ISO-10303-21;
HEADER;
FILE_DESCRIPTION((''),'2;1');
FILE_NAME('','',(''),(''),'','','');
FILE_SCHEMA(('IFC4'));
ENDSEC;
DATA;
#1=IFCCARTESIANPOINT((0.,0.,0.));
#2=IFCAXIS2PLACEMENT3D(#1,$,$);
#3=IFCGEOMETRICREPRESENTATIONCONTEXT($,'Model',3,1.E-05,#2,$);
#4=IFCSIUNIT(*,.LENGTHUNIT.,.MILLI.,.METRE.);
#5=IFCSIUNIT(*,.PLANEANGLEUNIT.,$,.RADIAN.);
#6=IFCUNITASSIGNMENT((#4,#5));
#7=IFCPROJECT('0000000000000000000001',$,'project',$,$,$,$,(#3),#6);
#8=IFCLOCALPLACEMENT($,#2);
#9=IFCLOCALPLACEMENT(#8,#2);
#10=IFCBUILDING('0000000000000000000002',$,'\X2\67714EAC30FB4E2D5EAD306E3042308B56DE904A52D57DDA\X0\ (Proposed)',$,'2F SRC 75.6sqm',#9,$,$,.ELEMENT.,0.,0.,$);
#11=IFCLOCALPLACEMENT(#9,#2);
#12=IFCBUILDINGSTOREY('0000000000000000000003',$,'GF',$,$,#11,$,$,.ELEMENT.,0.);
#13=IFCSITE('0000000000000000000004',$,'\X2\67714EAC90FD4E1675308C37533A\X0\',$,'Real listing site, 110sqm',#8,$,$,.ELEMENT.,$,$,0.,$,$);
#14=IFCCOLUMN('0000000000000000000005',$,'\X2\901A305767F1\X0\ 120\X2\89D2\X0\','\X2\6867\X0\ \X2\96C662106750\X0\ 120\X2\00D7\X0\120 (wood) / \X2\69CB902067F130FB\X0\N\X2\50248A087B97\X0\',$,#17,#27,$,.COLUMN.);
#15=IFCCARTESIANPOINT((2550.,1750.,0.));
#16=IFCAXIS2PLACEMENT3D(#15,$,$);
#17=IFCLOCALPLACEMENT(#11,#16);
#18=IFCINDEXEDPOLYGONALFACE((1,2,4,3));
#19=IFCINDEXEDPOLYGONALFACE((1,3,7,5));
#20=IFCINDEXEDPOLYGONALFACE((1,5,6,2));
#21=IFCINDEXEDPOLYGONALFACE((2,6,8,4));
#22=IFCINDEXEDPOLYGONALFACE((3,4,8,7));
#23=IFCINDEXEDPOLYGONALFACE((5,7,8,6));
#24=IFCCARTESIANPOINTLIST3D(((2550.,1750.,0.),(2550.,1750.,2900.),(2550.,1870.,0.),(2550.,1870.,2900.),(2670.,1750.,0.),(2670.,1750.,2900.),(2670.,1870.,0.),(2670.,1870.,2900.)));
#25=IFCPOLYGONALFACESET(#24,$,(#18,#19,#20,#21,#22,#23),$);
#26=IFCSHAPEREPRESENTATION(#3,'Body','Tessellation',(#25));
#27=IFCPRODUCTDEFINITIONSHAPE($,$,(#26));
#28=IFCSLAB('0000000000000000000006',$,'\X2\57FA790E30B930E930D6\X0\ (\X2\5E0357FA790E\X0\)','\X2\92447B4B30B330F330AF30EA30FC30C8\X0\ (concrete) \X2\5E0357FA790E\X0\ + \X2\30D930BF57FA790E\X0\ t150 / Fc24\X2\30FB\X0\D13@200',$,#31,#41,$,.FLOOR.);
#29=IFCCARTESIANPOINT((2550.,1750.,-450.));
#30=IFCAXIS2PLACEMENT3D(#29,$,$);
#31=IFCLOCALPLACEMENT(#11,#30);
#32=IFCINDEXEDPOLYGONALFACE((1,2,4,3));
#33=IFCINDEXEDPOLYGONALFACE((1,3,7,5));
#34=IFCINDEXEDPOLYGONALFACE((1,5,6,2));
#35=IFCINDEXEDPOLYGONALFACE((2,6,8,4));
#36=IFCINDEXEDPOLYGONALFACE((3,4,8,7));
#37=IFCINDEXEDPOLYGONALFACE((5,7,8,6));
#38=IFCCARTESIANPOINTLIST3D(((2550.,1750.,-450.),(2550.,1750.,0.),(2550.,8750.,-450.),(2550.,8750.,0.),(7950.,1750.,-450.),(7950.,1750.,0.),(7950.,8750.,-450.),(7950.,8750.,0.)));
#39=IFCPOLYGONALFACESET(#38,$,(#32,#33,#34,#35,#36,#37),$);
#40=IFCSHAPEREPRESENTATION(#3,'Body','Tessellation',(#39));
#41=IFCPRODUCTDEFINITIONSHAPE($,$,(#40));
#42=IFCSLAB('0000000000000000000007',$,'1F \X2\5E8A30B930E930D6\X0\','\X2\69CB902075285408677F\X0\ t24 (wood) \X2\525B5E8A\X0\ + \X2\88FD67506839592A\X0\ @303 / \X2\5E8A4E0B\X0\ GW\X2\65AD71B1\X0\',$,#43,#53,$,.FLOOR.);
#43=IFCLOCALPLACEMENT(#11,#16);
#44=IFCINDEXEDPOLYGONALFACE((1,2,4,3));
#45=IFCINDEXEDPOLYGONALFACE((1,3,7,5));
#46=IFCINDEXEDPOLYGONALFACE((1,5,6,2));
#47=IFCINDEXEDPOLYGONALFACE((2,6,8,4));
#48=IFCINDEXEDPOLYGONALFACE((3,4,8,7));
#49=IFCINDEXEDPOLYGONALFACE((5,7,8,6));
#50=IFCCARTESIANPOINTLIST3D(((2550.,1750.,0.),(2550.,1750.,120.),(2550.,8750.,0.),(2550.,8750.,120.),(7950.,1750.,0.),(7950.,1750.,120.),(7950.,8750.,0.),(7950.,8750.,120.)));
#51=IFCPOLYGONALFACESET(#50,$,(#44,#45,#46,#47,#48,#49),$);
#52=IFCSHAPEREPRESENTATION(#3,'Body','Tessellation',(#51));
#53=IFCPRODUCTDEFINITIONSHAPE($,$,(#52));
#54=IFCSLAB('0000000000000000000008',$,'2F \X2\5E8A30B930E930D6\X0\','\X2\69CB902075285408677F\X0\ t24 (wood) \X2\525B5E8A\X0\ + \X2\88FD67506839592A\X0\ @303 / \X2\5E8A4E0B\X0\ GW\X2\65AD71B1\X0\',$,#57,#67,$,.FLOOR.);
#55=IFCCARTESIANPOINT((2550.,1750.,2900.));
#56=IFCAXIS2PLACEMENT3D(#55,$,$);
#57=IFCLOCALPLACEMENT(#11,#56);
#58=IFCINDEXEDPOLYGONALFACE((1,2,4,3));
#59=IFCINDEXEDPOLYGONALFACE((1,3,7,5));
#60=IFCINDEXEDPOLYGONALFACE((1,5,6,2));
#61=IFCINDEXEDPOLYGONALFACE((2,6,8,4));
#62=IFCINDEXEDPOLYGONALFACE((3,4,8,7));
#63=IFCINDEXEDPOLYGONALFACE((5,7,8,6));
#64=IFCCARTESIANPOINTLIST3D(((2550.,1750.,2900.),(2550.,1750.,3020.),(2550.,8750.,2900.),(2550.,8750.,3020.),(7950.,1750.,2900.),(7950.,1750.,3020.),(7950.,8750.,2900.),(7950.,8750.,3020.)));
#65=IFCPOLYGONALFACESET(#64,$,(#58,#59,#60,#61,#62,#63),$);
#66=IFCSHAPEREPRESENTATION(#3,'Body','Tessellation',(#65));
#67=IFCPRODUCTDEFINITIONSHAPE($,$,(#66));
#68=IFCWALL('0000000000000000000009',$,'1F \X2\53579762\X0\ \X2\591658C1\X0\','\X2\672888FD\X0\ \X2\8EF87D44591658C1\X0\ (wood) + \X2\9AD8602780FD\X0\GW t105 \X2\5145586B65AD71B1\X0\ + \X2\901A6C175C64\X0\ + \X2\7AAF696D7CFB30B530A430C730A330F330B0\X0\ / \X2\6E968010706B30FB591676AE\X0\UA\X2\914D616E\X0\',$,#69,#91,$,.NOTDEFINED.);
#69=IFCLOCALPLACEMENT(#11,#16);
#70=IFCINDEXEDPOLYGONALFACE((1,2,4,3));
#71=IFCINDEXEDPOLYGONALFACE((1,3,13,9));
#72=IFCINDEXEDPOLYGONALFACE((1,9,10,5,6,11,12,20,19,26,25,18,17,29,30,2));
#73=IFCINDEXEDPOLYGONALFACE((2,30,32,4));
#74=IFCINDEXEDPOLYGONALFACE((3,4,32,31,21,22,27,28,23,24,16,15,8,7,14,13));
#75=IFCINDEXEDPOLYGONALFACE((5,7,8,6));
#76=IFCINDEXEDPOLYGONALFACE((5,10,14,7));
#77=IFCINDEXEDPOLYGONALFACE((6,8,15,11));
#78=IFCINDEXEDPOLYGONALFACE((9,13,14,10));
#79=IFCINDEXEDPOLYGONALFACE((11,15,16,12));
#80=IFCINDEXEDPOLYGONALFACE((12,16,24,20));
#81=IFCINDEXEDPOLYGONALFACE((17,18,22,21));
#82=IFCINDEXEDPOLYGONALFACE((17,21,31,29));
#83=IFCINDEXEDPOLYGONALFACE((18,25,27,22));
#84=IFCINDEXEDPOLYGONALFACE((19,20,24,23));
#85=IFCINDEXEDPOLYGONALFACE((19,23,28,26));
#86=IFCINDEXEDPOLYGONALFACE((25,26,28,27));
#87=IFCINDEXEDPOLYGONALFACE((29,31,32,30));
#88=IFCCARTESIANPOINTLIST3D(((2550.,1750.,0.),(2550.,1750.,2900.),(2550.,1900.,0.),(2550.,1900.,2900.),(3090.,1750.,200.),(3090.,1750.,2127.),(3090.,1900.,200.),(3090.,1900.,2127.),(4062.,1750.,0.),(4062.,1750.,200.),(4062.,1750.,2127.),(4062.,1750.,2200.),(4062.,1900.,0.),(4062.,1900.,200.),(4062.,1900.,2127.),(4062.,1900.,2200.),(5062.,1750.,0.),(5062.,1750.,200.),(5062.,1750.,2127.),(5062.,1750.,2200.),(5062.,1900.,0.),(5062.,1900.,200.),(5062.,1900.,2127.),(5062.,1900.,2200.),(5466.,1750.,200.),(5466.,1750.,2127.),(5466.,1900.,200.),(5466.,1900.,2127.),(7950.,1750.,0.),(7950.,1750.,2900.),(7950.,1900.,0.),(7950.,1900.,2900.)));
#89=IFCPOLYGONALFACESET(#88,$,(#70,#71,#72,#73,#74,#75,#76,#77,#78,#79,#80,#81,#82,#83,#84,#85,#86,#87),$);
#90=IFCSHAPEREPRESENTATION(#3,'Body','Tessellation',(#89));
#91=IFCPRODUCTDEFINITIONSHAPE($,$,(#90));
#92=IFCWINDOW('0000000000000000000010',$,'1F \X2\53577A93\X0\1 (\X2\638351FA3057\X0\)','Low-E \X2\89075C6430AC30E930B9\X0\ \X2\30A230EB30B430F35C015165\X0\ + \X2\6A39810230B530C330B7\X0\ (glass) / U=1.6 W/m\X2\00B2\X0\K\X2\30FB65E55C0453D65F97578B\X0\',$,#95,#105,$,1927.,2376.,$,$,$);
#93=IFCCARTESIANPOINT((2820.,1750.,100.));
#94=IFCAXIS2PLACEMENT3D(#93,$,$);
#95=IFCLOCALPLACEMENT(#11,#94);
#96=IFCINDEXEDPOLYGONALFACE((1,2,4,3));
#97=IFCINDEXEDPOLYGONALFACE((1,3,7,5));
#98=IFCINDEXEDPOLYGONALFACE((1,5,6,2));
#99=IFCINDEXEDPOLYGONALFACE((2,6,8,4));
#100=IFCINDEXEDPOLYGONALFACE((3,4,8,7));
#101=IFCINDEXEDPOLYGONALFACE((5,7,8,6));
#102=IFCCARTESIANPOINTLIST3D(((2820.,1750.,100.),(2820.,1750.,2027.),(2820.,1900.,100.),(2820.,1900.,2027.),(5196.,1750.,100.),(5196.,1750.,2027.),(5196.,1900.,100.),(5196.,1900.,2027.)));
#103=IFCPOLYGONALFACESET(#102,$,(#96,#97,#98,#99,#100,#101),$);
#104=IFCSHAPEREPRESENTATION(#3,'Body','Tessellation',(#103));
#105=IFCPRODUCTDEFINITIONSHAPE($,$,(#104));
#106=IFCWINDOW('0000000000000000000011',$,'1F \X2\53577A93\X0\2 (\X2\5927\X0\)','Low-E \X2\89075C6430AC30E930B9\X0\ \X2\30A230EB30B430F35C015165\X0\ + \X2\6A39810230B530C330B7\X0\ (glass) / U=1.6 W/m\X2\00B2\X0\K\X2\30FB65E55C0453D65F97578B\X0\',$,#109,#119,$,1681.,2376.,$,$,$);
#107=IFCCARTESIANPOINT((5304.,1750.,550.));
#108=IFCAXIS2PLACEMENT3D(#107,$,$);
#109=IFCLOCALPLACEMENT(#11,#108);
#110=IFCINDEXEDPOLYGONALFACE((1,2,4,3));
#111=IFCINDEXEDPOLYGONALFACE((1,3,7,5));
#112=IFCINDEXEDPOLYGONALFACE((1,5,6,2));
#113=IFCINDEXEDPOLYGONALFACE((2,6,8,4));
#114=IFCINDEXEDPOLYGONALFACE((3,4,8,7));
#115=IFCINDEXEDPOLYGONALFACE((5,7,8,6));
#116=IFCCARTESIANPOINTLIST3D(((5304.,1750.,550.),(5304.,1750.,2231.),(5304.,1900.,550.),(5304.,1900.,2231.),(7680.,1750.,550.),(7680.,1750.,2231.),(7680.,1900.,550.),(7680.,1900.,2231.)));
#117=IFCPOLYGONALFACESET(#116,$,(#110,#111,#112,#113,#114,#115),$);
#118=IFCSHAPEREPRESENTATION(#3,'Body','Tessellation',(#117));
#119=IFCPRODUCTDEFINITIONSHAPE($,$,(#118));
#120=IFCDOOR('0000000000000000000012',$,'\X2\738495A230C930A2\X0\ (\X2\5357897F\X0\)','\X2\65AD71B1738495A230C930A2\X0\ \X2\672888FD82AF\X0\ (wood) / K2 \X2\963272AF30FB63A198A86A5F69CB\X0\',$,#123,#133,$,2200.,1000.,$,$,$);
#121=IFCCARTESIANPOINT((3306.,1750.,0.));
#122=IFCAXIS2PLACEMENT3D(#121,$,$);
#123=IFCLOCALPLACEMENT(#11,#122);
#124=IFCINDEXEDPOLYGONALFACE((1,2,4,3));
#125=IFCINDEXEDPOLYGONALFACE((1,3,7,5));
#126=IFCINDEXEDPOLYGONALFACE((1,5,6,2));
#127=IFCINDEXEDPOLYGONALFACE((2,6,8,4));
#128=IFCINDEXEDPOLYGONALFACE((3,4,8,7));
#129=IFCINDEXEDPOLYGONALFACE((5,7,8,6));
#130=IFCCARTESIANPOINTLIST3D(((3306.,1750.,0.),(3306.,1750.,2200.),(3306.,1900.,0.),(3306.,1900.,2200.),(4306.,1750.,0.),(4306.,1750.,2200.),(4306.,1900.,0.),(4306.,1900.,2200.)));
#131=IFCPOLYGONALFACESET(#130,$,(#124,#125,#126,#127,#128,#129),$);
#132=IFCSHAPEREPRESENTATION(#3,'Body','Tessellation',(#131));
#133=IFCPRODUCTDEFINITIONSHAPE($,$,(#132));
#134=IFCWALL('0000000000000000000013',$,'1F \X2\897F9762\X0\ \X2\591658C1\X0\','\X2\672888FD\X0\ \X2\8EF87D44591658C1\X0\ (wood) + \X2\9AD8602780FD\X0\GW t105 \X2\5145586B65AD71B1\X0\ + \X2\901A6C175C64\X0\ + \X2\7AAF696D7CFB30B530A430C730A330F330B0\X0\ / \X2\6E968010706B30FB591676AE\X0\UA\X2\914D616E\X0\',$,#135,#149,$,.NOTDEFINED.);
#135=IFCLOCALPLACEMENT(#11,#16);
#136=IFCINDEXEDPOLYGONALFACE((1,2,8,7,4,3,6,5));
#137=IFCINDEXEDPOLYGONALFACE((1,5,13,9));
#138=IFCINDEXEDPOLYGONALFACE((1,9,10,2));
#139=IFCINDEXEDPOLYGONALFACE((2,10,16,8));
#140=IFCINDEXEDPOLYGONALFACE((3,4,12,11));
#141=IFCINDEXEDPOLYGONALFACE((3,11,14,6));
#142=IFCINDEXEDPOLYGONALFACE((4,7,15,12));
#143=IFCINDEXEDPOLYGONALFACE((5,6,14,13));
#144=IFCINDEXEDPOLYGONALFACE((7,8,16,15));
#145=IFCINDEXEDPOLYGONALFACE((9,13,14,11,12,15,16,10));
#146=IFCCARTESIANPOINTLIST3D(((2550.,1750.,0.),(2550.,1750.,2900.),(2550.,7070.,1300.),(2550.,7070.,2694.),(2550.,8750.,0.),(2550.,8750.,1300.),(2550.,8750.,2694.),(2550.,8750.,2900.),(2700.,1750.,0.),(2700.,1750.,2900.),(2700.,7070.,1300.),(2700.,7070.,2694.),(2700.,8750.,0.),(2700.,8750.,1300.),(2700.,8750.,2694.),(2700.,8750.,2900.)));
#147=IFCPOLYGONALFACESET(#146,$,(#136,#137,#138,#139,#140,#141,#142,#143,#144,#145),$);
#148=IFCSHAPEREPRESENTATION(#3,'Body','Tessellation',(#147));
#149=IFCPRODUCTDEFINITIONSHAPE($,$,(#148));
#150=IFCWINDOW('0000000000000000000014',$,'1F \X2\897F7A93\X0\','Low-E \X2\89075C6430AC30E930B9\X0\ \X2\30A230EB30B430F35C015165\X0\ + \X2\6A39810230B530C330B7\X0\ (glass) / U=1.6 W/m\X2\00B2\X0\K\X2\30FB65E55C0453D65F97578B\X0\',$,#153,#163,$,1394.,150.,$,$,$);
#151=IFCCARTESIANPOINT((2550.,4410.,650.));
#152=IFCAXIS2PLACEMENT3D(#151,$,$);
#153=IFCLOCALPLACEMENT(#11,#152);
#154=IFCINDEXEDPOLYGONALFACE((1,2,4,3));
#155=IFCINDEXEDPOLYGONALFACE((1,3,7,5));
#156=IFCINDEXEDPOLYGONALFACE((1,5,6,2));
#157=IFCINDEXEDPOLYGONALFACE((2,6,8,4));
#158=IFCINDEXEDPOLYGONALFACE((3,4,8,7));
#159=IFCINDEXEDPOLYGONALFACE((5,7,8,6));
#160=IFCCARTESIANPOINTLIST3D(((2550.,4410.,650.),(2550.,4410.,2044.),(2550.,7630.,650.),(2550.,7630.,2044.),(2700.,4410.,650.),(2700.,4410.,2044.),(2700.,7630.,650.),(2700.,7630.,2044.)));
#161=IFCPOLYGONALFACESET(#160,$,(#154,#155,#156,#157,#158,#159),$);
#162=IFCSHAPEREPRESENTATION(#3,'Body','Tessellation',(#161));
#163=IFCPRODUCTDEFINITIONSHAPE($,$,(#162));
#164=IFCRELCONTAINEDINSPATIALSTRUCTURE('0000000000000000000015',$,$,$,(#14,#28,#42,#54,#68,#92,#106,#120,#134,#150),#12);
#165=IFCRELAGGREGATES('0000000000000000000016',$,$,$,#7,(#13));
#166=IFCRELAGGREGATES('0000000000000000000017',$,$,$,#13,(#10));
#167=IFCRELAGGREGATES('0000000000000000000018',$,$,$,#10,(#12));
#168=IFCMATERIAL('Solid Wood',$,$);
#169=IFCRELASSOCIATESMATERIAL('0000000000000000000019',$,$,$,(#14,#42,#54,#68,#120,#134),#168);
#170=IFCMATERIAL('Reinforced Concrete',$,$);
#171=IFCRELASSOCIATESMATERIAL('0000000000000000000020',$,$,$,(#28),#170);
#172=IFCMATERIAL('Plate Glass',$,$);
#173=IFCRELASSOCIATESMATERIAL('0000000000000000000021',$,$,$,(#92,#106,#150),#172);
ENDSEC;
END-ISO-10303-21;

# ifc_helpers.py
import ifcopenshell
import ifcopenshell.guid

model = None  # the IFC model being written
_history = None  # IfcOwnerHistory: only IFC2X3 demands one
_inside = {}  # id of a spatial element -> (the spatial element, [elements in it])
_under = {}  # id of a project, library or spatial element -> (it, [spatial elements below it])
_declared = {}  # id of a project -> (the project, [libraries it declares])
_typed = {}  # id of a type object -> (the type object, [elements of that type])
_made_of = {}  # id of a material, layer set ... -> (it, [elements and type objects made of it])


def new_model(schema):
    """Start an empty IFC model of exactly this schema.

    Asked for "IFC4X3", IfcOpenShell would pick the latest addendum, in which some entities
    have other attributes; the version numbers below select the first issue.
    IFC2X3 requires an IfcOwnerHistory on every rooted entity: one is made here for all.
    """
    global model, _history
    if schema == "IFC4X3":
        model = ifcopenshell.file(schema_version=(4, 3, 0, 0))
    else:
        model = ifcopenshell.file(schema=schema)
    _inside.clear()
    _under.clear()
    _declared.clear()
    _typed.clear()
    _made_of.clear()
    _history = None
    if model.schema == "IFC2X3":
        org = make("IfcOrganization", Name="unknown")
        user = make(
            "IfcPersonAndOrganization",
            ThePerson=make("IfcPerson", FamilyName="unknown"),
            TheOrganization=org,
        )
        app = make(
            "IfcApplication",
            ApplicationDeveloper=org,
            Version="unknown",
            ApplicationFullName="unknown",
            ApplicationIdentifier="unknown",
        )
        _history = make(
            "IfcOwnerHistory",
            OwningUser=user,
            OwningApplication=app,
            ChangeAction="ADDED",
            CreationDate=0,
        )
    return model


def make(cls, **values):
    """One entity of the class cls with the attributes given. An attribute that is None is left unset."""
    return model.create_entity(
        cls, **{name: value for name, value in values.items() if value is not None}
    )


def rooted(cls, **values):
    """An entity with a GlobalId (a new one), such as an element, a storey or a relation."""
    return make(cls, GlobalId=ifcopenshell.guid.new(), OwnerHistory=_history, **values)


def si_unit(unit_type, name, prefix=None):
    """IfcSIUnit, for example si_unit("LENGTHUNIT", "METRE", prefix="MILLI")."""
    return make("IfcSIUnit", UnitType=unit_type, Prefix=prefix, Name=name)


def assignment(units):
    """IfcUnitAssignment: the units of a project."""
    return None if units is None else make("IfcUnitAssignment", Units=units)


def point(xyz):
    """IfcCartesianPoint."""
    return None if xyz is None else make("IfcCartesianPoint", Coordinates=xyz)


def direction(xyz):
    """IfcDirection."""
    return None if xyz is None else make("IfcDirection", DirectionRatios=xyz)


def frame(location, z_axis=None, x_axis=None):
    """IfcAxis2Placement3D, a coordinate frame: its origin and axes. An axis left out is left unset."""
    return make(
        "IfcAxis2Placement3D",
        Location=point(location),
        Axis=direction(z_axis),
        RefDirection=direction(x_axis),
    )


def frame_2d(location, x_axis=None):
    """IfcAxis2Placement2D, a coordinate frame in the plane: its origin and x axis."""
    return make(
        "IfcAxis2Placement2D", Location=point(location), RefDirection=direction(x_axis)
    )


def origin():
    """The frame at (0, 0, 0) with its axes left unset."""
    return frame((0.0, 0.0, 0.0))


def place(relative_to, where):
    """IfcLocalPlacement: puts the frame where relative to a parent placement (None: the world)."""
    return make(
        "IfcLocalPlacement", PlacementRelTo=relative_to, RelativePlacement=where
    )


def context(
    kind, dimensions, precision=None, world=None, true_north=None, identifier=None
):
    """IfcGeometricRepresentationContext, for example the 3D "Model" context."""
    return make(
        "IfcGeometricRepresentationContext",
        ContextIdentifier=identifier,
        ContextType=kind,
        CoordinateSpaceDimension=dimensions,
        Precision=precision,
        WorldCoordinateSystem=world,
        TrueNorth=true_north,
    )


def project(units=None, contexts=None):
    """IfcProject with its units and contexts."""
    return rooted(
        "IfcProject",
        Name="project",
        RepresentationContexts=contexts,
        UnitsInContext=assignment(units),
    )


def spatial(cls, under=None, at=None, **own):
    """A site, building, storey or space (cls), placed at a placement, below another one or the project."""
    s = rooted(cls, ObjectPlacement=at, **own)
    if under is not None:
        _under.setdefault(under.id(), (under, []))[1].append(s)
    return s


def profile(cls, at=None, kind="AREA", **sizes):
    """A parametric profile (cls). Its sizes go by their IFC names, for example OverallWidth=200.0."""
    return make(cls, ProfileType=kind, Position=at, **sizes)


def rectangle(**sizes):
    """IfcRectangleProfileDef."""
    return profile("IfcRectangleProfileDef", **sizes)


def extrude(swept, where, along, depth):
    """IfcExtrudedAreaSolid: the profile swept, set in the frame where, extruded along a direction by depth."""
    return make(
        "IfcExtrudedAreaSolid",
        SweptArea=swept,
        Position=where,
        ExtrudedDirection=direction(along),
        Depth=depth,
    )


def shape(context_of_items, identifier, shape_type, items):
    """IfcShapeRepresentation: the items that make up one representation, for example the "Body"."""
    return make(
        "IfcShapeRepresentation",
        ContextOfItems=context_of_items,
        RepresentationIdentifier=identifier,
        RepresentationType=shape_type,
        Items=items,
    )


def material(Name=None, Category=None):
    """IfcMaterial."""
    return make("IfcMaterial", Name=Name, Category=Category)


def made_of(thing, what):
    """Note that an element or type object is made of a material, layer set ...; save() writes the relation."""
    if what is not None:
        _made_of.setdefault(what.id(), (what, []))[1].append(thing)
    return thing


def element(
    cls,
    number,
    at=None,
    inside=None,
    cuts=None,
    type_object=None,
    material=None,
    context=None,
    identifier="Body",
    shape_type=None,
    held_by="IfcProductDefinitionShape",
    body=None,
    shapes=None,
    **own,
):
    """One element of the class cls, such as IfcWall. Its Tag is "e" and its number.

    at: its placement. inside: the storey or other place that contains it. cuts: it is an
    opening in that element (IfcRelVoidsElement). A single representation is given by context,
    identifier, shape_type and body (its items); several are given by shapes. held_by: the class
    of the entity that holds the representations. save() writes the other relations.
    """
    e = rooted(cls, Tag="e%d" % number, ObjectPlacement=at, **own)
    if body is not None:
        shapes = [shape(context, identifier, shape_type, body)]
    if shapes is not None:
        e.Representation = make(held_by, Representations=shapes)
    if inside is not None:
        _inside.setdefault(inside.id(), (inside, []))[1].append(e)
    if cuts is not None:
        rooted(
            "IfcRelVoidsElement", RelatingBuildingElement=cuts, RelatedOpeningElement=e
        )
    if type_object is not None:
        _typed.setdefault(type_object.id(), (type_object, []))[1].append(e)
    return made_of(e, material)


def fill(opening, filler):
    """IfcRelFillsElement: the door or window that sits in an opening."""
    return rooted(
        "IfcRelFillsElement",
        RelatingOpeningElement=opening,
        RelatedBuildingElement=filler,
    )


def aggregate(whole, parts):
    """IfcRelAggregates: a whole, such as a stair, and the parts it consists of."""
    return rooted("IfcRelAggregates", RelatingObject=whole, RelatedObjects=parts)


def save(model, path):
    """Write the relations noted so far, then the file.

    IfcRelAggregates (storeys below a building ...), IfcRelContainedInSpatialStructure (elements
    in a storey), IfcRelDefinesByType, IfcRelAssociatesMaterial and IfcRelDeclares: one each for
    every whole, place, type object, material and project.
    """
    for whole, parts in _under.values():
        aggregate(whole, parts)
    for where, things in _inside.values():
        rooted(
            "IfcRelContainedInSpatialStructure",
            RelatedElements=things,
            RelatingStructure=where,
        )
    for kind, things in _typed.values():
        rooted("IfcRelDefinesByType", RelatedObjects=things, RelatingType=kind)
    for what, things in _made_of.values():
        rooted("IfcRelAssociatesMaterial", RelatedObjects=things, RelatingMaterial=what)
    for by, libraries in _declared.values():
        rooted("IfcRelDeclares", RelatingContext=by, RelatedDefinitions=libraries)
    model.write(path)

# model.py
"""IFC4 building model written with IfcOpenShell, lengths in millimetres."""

from ifc_helpers import new_model, si_unit, frame, frame_2d, origin, place, context, project, spatial, rectangle, extrude, material, element, fill, save


model = new_model("IFC4")

# Units and contexts
model_context = context("Model", 3, precision=1e-05, world=origin())
ifc_project = project(units=[si_unit("LENGTHUNIT", "METRE", prefix="MILLI"), si_unit("PLANEANGLEUNIT", "RADIAN")], contexts=[model_context])

# Site, building, storey
site_placement = place(None, origin())
site = spatial("IfcSite", under=ifc_project, at=site_placement, Name="東京都世田谷区", ObjectType="Real listing site, 110sqm", CompositionType="ELEMENT", RefElevation=0.0)
building_placement = place(site_placement, origin())
building = spatial("IfcBuilding", under=site, at=building_placement, Name="東京・中庭のある回遊動線 (Proposed)", ObjectType="2F SRC 75.6sqm", CompositionType="ELEMENT", ElevationOfRefHeight=0.0, ElevationOfTerrain=0.0)
storey_placement = place(building_placement, origin())
storey = spatial("IfcBuildingStorey", under=building, at=storey_placement, Name="GF", CompositionType="ELEMENT", Elevation=0.0)

# Column
ifc_material_1 = material(Name="Solid Wood")
column_placement = place(storey_placement, frame((2550.0, 1750.0, 0.0)))
element("IfcColumn", 1, at=column_placement, inside=storey, material=ifc_material_1, Name="通し柱 120角", Description="桧 集成材 120×120 (wood) / 構造柱・N値計算", PredefinedType="COLUMN", context=model_context, shape_type="SweptSolid", body=[
    extrude(rectangle(XDim=120.0, YDim=120.0, at=frame_2d((60.0, 60.0))), frame((2550.0, 1750.0, 0.0)), (0.0, 0.0, 1.0), 2900.0),
])

# Slabs
ifc_material_2 = material(Name="Reinforced Concrete")
slab_1_placement = place(storey_placement, frame((2550.0, 1750.0, -450.0)))
element("IfcSlab", 2, at=slab_1_placement, inside=storey, material=ifc_material_2, Name="基礎スラブ (布基礎)", Description="鉄筋コンクリート (concrete) 布基礎 + ベタ基礎 t150 / Fc24・D13@200", PredefinedType="FLOOR", context=model_context, shape_type="SweptSolid", body=[
    extrude(rectangle(XDim=5400.0, YDim=7000.0, at=frame_2d((2700.0, 3500.0))), frame((2550.0, 1750.0, -450.0)), (0.0, 0.0, 1.0), 450.0),
])
slab_2_placement = place(storey_placement, frame((2550.0, 1750.0, 0.0)))
element("IfcSlab", 3, at=slab_2_placement, inside=storey, material=ifc_material_1, Name="1F 床スラブ", Description="構造用合板 t24 (wood) 剛床 + 製材根太 @303 / 床下 GW断熱", PredefinedType="FLOOR", context=model_context, shape_type="SweptSolid", body=[
    extrude(rectangle(XDim=5400.0, YDim=7000.0, at=frame_2d((2700.0, 3500.0))), frame((2550.0, 1750.0, 0.0)), (0.0, 0.0, 1.0), 120.0),
])
slab_3_placement = place(storey_placement, frame((2550.0, 1750.0, 2900.0)))
element("IfcSlab", 4, at=slab_3_placement, inside=storey, material=ifc_material_1, Name="2F 床スラブ", Description="構造用合板 t24 (wood) 剛床 + 製材根太 @303 / 床下 GW断熱", PredefinedType="FLOOR", context=model_context, shape_type="SweptSolid", body=[
    extrude(rectangle(XDim=5400.0, YDim=7000.0, at=frame_2d((2700.0, 3500.0))), frame((2550.0, 1750.0, 2900.0)), (0.0, 0.0, 1.0), 120.0),
])

# Wall, openings, windows, door
wall_1_placement = place(storey_placement, frame((2550.0, 1750.0, 0.0)))
wall_1 = element("IfcWall", 5, at=wall_1_placement, inside=storey, material=ifc_material_1, Name="1F 南面 外壁", Description="木製 軸組外壁 (wood) + 高性能GW t105 充填断熱 + 通気層 + 窯業系サイディング / 準耐火・外皮UA配慮", PredefinedType="NOTDEFINED", context=model_context, shape_type="SweptSolid", body=[
    extrude(rectangle(XDim=5400.0, YDim=150.0, at=frame_2d((2700.0, 75.0))), frame((2550.0, 1750.0, 0.0)), (0.0, 0.0, 1.0), 2900.0),
])
opening_1_placement = place(storey_placement, frame((2820.0, 1750.0, 100.0)))
opening_1 = element("IfcOpeningElement", 6, at=opening_1_placement, cuts=wall_1, PredefinedType="NOTDEFINED", context=model_context, shape_type="SweptSolid", body=[
    extrude(rectangle(XDim=2376.0, YDim=150.0, at=frame_2d((1188.0, 75.0))), frame((2820.0, 1750.0, 100.0)), (0.0, 0.0, 1.0), 1927.0),
])
opening_2_placement = place(storey_placement, frame((5304.0, 1750.0, 550.0)))
opening_2 = element("IfcOpeningElement", 7, at=opening_2_placement, cuts=wall_1, PredefinedType="NOTDEFINED", context=model_context, shape_type="SweptSolid", body=[
    extrude(rectangle(XDim=2376.0, YDim=150.0, at=frame_2d((1188.0, 75.0))), frame((5304.0, 1750.0, 550.0)), (0.0, 0.0, 1.0), 1681.0),
])
opening_3_placement = place(storey_placement, frame((3306.0, 1750.0, 0.0)))
opening_3 = element("IfcOpeningElement", 8, at=opening_3_placement, cuts=wall_1, PredefinedType="NOTDEFINED", context=model_context, shape_type="SweptSolid", body=[
    extrude(rectangle(XDim=1000.0, YDim=150.0, at=frame_2d((500.0, 75.0))), frame((3306.0, 1750.0, 0.0)), (0.0, 0.0, 1.0), 2200.0),
])
ifc_material_3 = material(Name="Plate Glass")
window_1_placement = place(storey_placement, frame((2820.0, 1750.0, 100.0)))
window_1 = element("IfcWindow", 9, at=window_1_placement, inside=storey, material=ifc_material_3, Name="1F 南窓1 (掃出し)", Description="Low-E 複層ガラス アルゴン封入 + 樹脂サッシ (glass) / U=1.6 W/m²K・日射取得型", OverallHeight=1927.0, OverallWidth=2376.0, context=model_context, shape_type="SweptSolid", body=[
    extrude(rectangle(XDim=2376.0, YDim=150.0, at=frame_2d((1188.0, 75.0))), frame((2820.0, 1750.0, 100.0)), (0.0, 0.0, 1.0), 1927.0),
])
fill(opening_1, window_1)
window_2_placement = place(storey_placement, frame((5304.0, 1750.0, 550.0)))
window_2 = element("IfcWindow", 10, at=window_2_placement, inside=storey, material=ifc_material_3, Name="1F 南窓2 (大)", Description="Low-E 複層ガラス アルゴン封入 + 樹脂サッシ (glass) / U=1.6 W/m²K・日射取得型", OverallHeight=1681.0, OverallWidth=2376.0, context=model_context, shape_type="SweptSolid", body=[
    extrude(rectangle(XDim=2376.0, YDim=150.0, at=frame_2d((1188.0, 75.0))), frame((5304.0, 1750.0, 550.0)), (0.0, 0.0, 1.0), 1681.0),
])
fill(opening_2, window_2)
door_placement = place(storey_placement, frame((3306.0, 1750.0, 0.0)))
door = element("IfcDoor", 11, at=door_placement, inside=storey, material=ifc_material_1, Name="玄関ドア (南西)", Description="断熱玄関ドア 木製芯 (wood) / K2 防犯・採風機構", OverallHeight=2200.0, OverallWidth=1000.0, context=model_context, shape_type="SweptSolid", body=[
    extrude(rectangle(XDim=1000.0, YDim=150.0, at=frame_2d((500.0, 75.0))), frame((3306.0, 1750.0, 0.0)), (0.0, 0.0, 1.0), 2200.0),
])
fill(opening_3, door)

# Wall, opening, window
wall_2_placement = place(storey_placement, frame((2550.0, 1750.0, 0.0)))
wall_2 = element("IfcWall", 12, at=wall_2_placement, inside=storey, material=ifc_material_1, Name="1F 西面 外壁", Description="木製 軸組外壁 (wood) + 高性能GW t105 充填断熱 + 通気層 + 窯業系サイディング / 準耐火・外皮UA配慮", PredefinedType="NOTDEFINED", context=model_context, shape_type="SweptSolid", body=[
    extrude(rectangle(XDim=150.0, YDim=7000.0, at=frame_2d((75.0, 3500.0))), frame((2550.0, 1750.0, 0.0)), (0.0, 0.0, 1.0), 2900.0),
])
opening_4_placement = place(storey_placement, frame((2550.0, 4410.0, 650.0)))
opening_4 = element("IfcOpeningElement", 13, at=opening_4_placement, cuts=wall_2, PredefinedType="NOTDEFINED", context=model_context, shape_type="SweptSolid", body=[
    extrude(rectangle(XDim=150.0, YDim=3220.0, at=frame_2d((75.0, 1610.0))), frame((2550.0, 4410.0, 650.0)), (0.0, 0.0, 1.0), 1394.0),
])
window_3_placement = place(storey_placement, frame((2550.0, 4410.0, 650.0)))
window_3 = element("IfcWindow", 14, at=window_3_placement, inside=storey, material=ifc_material_3, Name="1F 西窓", Description="Low-E 複層ガラス アルゴン封入 + 樹脂サッシ (glass) / U=1.6 W/m²K・日射取得型", OverallHeight=1394.0, OverallWidth=150.0, context=model_context, shape_type="SweptSolid", body=[
    extrude(rectangle(XDim=150.0, YDim=3220.0, at=frame_2d((75.0, 1610.0))), frame((2550.0, 4410.0, 650.0)), (0.0, 0.0, 1.0), 1394.0),
])
fill(opening_4, window_3)

save(model, "model.ifc")
